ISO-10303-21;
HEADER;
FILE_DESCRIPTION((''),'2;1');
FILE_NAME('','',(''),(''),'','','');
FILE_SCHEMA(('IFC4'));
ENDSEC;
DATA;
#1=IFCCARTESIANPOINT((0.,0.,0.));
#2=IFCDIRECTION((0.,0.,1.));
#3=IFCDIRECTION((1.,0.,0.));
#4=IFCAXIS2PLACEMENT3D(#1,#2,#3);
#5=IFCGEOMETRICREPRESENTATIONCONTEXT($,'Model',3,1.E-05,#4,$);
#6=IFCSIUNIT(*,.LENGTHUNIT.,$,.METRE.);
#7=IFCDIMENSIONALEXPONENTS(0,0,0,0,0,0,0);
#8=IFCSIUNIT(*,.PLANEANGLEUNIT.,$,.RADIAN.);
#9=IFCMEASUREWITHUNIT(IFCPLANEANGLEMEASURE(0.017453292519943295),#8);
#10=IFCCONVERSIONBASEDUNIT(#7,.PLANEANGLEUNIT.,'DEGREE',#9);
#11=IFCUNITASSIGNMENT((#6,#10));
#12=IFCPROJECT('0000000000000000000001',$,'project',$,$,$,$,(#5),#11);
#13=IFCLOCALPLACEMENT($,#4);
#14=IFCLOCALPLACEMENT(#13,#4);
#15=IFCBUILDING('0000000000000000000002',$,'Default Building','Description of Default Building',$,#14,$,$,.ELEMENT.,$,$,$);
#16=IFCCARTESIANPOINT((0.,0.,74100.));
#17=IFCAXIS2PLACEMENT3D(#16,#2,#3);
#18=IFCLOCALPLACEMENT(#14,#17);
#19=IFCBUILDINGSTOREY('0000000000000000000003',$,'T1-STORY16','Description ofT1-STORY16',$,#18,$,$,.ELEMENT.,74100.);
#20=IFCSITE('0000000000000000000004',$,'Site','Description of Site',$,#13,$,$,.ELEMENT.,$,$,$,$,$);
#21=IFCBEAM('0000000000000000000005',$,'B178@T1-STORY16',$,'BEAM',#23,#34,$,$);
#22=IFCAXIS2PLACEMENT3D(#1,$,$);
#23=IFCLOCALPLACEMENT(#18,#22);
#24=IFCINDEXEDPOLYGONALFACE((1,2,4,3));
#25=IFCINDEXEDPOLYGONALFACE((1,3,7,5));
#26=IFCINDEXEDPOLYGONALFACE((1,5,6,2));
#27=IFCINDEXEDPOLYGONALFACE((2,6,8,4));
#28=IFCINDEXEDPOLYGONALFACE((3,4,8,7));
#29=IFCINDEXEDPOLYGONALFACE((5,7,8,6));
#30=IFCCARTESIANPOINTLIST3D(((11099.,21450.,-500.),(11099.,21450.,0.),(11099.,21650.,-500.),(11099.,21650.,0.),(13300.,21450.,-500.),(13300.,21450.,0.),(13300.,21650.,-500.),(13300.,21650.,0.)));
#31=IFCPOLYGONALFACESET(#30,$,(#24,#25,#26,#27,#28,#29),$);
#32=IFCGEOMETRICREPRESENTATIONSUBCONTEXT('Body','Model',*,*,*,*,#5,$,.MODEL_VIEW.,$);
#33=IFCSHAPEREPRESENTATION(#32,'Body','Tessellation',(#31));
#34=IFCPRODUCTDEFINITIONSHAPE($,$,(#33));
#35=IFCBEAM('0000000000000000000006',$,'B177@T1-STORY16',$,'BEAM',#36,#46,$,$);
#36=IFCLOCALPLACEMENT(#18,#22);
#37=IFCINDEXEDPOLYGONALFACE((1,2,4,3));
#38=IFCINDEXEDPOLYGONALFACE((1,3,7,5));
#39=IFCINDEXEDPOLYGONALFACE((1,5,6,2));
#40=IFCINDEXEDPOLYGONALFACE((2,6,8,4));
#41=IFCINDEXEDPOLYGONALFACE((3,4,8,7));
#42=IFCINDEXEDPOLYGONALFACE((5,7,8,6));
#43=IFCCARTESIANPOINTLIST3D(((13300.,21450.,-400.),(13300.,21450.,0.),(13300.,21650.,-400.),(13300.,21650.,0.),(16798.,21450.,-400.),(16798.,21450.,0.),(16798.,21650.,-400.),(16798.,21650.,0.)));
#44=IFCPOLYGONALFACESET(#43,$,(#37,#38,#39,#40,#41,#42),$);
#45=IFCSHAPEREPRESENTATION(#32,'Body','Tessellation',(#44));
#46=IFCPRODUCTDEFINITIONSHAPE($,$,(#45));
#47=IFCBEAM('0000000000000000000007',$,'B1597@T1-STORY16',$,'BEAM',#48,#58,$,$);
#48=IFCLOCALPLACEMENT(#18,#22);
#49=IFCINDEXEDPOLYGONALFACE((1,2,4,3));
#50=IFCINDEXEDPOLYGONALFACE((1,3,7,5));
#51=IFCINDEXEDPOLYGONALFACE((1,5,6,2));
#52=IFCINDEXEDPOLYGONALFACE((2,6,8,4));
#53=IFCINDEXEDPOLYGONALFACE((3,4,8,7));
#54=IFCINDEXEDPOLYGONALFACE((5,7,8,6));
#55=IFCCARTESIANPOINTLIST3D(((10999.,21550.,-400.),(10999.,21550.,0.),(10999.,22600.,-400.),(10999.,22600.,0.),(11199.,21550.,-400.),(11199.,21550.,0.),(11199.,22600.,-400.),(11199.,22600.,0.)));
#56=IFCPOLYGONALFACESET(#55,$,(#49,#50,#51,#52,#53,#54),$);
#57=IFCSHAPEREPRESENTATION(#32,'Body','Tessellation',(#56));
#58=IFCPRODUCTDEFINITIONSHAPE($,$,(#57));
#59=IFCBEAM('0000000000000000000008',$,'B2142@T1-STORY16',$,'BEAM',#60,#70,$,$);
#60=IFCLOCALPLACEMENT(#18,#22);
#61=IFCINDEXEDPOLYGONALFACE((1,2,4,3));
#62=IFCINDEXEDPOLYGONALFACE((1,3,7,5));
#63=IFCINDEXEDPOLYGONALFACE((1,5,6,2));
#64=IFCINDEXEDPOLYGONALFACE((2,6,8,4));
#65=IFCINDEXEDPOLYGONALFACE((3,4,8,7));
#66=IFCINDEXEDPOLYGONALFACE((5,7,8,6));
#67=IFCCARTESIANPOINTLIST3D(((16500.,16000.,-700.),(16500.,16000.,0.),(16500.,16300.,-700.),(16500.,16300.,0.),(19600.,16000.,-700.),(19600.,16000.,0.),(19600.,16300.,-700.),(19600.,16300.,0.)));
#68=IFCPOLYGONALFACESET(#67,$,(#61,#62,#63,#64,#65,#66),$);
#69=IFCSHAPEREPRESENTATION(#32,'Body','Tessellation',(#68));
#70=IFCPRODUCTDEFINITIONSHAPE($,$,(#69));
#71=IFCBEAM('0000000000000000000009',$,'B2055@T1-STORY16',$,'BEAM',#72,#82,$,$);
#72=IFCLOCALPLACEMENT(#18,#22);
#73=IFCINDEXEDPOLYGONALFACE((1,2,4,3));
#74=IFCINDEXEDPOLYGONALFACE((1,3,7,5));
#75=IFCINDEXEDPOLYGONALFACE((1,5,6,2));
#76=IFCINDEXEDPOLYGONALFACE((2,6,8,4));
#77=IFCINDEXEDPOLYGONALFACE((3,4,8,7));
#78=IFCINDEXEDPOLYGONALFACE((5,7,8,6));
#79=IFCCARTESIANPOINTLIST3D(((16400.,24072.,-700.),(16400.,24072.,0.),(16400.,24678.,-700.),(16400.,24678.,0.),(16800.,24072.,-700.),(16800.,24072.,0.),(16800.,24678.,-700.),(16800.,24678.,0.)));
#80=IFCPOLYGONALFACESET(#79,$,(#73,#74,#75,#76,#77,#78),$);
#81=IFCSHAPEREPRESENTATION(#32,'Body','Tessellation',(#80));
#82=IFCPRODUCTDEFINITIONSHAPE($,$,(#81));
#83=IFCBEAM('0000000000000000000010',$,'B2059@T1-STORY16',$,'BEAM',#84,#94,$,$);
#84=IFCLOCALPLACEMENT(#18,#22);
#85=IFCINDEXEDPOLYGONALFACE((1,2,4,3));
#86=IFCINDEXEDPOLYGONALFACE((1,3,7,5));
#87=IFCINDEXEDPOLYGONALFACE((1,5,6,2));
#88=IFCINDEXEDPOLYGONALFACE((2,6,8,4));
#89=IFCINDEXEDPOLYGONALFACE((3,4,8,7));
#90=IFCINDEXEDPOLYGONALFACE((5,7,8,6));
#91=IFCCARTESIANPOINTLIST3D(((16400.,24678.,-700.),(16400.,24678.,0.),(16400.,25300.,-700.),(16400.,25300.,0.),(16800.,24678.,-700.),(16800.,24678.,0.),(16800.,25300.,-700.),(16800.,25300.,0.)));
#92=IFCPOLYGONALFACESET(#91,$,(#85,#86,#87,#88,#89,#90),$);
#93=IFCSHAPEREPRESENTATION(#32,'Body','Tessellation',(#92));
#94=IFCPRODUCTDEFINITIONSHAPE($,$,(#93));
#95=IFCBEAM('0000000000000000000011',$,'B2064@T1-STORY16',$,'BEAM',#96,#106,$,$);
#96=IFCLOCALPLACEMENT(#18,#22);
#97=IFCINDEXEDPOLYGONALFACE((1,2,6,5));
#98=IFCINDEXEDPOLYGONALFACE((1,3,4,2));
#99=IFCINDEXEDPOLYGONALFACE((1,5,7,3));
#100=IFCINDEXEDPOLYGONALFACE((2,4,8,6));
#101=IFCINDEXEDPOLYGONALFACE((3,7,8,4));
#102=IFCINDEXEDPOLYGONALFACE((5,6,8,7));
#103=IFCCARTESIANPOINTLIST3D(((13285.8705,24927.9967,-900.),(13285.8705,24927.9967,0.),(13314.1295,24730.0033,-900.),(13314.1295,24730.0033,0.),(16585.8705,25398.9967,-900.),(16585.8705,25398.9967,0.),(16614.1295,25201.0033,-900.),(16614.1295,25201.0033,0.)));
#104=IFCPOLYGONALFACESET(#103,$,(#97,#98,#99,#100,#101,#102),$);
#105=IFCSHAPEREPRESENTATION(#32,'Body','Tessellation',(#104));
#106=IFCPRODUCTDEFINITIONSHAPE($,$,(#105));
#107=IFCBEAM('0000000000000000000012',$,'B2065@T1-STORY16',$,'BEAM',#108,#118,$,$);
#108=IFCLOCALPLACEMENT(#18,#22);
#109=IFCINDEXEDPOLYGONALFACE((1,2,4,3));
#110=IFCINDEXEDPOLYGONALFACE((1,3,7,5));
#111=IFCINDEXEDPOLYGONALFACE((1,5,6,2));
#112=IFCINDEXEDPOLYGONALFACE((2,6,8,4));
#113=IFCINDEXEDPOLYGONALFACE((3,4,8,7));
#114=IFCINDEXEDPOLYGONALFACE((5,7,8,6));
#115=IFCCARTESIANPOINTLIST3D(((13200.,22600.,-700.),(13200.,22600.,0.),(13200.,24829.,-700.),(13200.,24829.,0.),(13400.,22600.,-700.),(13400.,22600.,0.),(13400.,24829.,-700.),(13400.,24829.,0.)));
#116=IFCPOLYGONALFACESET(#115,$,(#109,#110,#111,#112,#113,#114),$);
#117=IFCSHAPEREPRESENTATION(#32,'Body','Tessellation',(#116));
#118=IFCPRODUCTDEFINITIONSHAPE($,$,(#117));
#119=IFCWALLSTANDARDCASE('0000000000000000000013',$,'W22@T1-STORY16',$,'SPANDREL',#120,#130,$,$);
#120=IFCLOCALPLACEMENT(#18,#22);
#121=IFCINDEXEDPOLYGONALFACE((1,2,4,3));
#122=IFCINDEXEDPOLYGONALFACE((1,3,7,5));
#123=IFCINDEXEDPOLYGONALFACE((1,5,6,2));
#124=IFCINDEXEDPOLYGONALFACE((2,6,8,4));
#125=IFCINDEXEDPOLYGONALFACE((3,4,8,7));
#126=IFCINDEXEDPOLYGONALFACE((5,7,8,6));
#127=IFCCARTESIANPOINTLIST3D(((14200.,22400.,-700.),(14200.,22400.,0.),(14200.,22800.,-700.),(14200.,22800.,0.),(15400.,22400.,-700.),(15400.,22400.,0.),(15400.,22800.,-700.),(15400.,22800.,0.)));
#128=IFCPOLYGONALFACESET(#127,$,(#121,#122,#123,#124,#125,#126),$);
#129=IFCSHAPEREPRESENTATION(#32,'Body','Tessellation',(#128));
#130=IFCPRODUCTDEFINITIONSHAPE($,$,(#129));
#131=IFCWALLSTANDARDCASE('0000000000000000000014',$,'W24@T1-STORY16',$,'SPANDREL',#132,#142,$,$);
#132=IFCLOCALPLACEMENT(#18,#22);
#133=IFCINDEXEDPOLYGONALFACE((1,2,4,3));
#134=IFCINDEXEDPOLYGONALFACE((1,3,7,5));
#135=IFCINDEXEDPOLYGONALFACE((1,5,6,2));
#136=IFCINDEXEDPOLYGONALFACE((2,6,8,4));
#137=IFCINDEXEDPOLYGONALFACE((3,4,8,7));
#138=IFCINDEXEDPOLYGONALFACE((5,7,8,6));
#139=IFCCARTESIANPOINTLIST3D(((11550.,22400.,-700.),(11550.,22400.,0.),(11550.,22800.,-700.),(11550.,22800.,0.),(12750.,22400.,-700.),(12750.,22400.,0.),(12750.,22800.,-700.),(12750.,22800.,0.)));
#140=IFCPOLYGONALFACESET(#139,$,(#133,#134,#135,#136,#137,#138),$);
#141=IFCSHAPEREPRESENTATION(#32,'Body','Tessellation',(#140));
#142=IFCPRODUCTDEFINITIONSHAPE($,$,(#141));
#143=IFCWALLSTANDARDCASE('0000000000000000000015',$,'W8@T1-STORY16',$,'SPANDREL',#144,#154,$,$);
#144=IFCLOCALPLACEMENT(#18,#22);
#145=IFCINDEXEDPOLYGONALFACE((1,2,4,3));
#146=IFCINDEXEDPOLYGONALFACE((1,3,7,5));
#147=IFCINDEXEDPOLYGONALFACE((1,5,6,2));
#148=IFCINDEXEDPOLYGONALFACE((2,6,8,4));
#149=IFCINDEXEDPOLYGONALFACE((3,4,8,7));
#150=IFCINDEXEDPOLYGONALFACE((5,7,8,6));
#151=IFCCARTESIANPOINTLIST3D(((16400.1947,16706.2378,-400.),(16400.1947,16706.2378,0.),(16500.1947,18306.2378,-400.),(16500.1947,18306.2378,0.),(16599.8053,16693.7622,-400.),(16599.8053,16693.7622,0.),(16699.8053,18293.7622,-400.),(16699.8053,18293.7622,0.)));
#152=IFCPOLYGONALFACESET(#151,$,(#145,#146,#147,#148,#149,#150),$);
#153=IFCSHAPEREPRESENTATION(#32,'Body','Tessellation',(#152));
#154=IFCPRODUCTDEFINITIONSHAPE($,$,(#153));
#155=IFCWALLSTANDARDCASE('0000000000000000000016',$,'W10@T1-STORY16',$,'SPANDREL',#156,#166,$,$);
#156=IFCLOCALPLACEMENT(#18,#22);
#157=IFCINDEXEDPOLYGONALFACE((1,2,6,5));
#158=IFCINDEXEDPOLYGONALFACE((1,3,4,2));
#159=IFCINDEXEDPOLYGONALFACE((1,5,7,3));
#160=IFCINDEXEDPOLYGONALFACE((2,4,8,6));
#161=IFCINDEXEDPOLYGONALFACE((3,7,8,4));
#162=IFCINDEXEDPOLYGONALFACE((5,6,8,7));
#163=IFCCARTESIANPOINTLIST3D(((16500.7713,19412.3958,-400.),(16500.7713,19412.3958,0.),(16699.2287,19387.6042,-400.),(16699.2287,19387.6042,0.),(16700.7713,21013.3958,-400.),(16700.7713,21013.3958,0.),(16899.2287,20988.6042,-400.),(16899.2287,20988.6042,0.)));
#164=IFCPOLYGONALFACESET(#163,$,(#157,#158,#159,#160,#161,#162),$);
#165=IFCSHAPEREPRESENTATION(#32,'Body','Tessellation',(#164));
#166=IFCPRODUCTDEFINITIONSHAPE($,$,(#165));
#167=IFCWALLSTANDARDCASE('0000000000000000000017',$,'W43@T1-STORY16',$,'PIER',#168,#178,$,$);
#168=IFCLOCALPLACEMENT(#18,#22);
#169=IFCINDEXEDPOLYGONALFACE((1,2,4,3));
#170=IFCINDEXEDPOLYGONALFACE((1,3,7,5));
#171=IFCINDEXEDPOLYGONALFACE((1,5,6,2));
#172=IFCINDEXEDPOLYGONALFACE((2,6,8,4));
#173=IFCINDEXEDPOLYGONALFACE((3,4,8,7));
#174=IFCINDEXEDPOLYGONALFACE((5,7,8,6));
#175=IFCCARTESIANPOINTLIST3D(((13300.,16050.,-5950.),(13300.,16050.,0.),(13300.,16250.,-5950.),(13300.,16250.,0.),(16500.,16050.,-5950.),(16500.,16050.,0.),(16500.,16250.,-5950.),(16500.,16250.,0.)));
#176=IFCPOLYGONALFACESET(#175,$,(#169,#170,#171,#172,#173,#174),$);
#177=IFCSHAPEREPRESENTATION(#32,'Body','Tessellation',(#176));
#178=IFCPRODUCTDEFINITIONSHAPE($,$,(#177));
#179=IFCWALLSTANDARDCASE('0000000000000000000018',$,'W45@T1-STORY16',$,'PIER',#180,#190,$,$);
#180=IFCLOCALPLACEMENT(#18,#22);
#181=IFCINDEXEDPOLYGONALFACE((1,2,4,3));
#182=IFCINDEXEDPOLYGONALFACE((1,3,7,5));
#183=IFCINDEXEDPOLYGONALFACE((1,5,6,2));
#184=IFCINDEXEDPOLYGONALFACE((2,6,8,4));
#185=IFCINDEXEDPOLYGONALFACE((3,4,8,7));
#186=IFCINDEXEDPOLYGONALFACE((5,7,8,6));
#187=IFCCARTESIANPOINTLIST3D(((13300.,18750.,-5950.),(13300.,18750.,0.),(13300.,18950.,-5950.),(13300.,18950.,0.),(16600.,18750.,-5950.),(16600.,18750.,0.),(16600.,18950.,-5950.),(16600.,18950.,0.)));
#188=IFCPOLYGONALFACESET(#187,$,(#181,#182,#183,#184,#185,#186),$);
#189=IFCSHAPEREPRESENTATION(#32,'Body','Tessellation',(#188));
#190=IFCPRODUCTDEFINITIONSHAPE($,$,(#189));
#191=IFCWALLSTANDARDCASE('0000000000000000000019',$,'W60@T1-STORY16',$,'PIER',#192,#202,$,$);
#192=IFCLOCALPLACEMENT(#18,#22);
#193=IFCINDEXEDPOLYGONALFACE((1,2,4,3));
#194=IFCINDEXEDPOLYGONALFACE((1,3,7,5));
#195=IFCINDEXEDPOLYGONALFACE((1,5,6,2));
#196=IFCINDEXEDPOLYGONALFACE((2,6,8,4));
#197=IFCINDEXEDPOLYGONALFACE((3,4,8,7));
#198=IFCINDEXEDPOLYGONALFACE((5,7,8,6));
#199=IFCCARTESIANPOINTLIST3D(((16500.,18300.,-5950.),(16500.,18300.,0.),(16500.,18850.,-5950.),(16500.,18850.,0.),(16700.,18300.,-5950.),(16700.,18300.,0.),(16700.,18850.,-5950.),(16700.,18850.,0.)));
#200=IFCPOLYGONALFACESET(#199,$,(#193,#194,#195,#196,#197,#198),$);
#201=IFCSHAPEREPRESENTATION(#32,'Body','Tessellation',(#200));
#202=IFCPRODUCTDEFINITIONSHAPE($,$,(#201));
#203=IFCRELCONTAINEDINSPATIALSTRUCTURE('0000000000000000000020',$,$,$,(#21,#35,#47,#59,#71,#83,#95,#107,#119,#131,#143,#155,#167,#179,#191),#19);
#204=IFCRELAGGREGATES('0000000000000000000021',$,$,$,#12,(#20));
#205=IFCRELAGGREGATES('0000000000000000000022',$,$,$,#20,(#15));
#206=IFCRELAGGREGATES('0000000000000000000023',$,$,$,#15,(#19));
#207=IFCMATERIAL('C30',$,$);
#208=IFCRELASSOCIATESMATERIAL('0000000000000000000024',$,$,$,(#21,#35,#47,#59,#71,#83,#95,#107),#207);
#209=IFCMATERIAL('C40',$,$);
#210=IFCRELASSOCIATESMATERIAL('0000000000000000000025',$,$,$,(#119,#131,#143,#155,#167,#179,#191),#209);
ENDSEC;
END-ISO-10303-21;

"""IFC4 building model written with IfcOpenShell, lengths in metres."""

from ifc_helpers import new_model, entity, si_unit, converted_unit, frame, origin_with_axes, place, context, subcontext, project, spatial, indexed_curve, rectangle, outline, extrude, material, element, save


model = new_model("IFC4")

# Units and contexts
model_context = context("Model", 3, precision=1e-05, world=origin_with_axes())
body_context = subcontext(model_context, "Body", "Model", "MODEL_VIEW")
ifc_project = project(units=[si_unit("LENGTHUNIT", "METRE"), converted_unit("PLANEANGLEUNIT", "DEGREE", entity("IfcPlaneAngleMeasure", 0.017453292519943295), si_unit("PLANEANGLEUNIT", "RADIAN"), dimensions=[0, 0, 0, 0, 0, 0, 0])], contexts=[model_context])

# Site, building, storey
site_placement = place(None, origin_with_axes())
site = spatial("IfcSite", under=ifc_project, at=site_placement, Name="Site", Description="Description of Site", CompositionType="ELEMENT")
building_placement = place(site_placement, origin_with_axes())
building = spatial("IfcBuilding", under=site, at=building_placement, Name="Default Building", Description="Description of Default Building", CompositionType="ELEMENT")
storey_placement = place(building_placement, frame((0.0, 0.0, 74100.0), z_axis=(0.0, 0.0, 1.0), x_axis=(1.0, 0.0, 0.0)))
storey = spatial("IfcBuildingStorey", under=building, at=storey_placement, Name="T1-STORY16", Description="Description ofT1-STORY16", CompositionType="ELEMENT", Elevation=74100.0)

# Beams
ifc_material_1 = material(Name="C30")
beam_1_placement = place(storey_placement, frame((11099.0, 21550.0, -250.0), z_axis=(1.0, 0.0, 0.0), x_axis=(0.0, 1.0, 0.0)))
element("IfcBeam", 1, at=beam_1_placement, inside=storey, material=ifc_material_1, Name="B178@T1-STORY16", ObjectType="BEAM", context=body_context, shape_type="SweptSolid", body=[
    extrude(rectangle(XDim=200.0, YDim=500.0), origin_with_axes(), (0.0, 0.0, 1.0), 2201.0),
])
beam_2_placement = place(storey_placement, frame((13300.0, 21550.0, -200.0), z_axis=(1.0, 0.0, 0.0), x_axis=(0.0, 1.0, 0.0)))
element("IfcBeam", 2, at=beam_2_placement, inside=storey, material=ifc_material_1, Name="B177@T1-STORY16", ObjectType="BEAM", context=body_context, shape_type="SweptSolid", body=[
    extrude(rectangle(XDim=200.0, YDim=400.0), origin_with_axes(), (0.0, 0.0, 1.0), 3498.0),
])
beam_3_placement = place(storey_placement, frame((11099.0, 21550.0, -200.0), z_axis=(0.0, 1.0, 0.0), x_axis=(-1.0, 0.0, 0.0)))
element("IfcBeam", 3, at=beam_3_placement, inside=storey, material=ifc_material_1, Name="B1597@T1-STORY16", ObjectType="BEAM", context=body_context, shape_type="SweptSolid", body=[
    extrude(rectangle(XDim=200.0, YDim=400.0), origin_with_axes(), (0.0, 0.0, 1.0), 1050.0),
])
beam_4_placement = place(storey_placement, frame((16500.0, 16150.0, -350.0), z_axis=(1.0, 0.0, 0.0), x_axis=(0.0, 1.0, 0.0)))
element("IfcBeam", 4, at=beam_4_placement, inside=storey, material=ifc_material_1, Name="B2142@T1-STORY16", ObjectType="BEAM", context=body_context, shape_type="SweptSolid", body=[
    extrude(rectangle(XDim=300.0, YDim=700.0), origin_with_axes(), (0.0, 0.0, 1.0), 3100.0),
])
beam_5_placement = place(storey_placement, frame((16600.0, 24072.0, -350.0), z_axis=(0.0, 1.0, 0.0), x_axis=(-1.0, 0.0, 0.0)))
element("IfcBeam", 5, at=beam_5_placement, inside=storey, material=ifc_material_1, Name="B2055@T1-STORY16", ObjectType="BEAM", context=body_context, shape_type="SweptSolid", body=[
    extrude(rectangle(XDim=400.0, YDim=700.0), origin_with_axes(), (0.0, 0.0, 1.0), 606.0),
])
beam_6_placement = place(storey_placement, frame((16600.0, 24678.0, -350.0), z_axis=(0.0, 1.0, 0.0), x_axis=(-1.0, 0.0, 0.0)))
element("IfcBeam", 6, at=beam_6_placement, inside=storey, material=ifc_material_1, Name="B2059@T1-STORY16", ObjectType="BEAM", context=body_context, shape_type="SweptSolid", body=[
    extrude(rectangle(XDim=400.0, YDim=700.0), origin_with_axes(), (0.0, 0.0, 1.0), 622.0),
])
beam_7_placement = place(storey_placement, frame((13300.0, 24829.0, -450.0), z_axis=(0.989967, 0.141295, 0.0), x_axis=(-0.141295, 0.989967, 0.0)))
element("IfcBeam", 7, at=beam_7_placement, inside=storey, material=ifc_material_1, Name="B2064@T1-STORY16", ObjectType="BEAM", context=body_context, shape_type="SweptSolid", body=[
    extrude(rectangle(XDim=200.0, YDim=900.0), origin_with_axes(), (0.0, 0.0, 1.0), 3333.4428),
])
beam_8_placement = place(storey_placement, frame((13300.0, 22600.0, -350.0), z_axis=(0.0, 1.0, 0.0), x_axis=(-1.0, 0.0, 0.0)))
element("IfcBeam", 8, at=beam_8_placement, inside=storey, material=ifc_material_1, Name="B2065@T1-STORY16", ObjectType="BEAM", context=body_context, shape_type="SweptSolid", body=[
    extrude(rectangle(XDim=200.0, YDim=700.0), origin_with_axes(), (0.0, 0.0, 1.0), 2229.0),
])

# Walls
ifc_material_2 = material(Name="C40")
for number, where, z_axis, x_axis, name in (
    (9, (14200.0, 22600.0, -700.0), (0.0, 0.0, 1.0), (1.0, 0.0, 0.0), "W22@T1-STORY16"),
    (10, (11550.0, 22600.0, -700.0), (0.0, 0.0, 1.0), (1.0, 0.0, 0.0), "W24@T1-STORY16"),
):
    element("IfcWallStandardCase", number, at=place(storey_placement, frame(where, z_axis=z_axis, x_axis=x_axis)), inside=storey, material=ifc_material_2, Name=name, ObjectType="SPANDREL", context=body_context, shape_type="SweptSolid", body=[
        extrude(outline(indexed_curve([(0.0, -200.0), (0.0, 200.0), (1200.0, 200.0), (1200.0, -200.0), (0.0, -200.0)], self_intersect=False)), origin_with_axes(), (0.0, 0.0, 1.0), 700.0),
    ])
wall_1_placement = place(storey_placement, frame((16500.0, 16700.0, -400.0), z_axis=(0.0, 0.0, 1.0), x_axis=(0.062378, 0.998053, 0.0)))
element("IfcWallStandardCase", 11, at=wall_1_placement, inside=storey, material=ifc_material_2, Name="W8@T1-STORY16", ObjectType="SPANDREL", context=body_context, shape_type="SweptSolid", body=[
    extrude(outline(indexed_curve([(0.0, -100.0), (0.0, 100.0), (1603.122, 100.0), (1603.122, -100.0), (0.0, -100.0)], self_intersect=False)), origin_with_axes(), (0.0, 0.0, 1.0), 400.0),
])
wall_2_placement = place(storey_placement, frame((16600.0, 19400.0, -400.0), z_axis=(0.0, 0.0, 1.0), x_axis=(0.123958, 0.992287, 0.0)))
element("IfcWallStandardCase", 12, at=wall_2_placement, inside=storey, material=ifc_material_2, Name="W10@T1-STORY16", ObjectType="SPANDREL", context=body_context, shape_type="SweptSolid", body=[
    extrude(outline(indexed_curve([(0.0, -100.0), (0.0, 100.0), (1613.4438, 100.0), (1613.4438, -100.0), (0.0, -100.0)], self_intersect=False)), origin_with_axes(), (0.0, 0.0, 1.0), 400.0),
])
wall_3_placement = place(storey_placement, frame((13300.0, 16150.0, -5950.0), z_axis=(0.0, 0.0, 1.0), x_axis=(1.0, 0.0, 0.0)))
element("IfcWallStandardCase", 13, at=wall_3_placement, inside=storey, material=ifc_material_2, Name="W43@T1-STORY16", ObjectType="PIER", context=body_context, shape_type="SweptSolid", body=[
    extrude(outline(indexed_curve([(0.0, -100.0), (0.0, 100.0), (3200.0, 100.0), (3200.0, -100.0), (0.0, -100.0)], self_intersect=False)), origin_with_axes(), (0.0, 0.0, 1.0), 5950.0),
])
wall_4_placement = place(storey_placement, frame((13300.0, 18850.0, -5950.0), z_axis=(0.0, 0.0, 1.0), x_axis=(1.0, 0.0, 0.0)))
element("IfcWallStandardCase", 14, at=wall_4_placement, inside=storey, material=ifc_material_2, Name="W45@T1-STORY16", ObjectType="PIER", context=body_context, shape_type="SweptSolid", body=[
    extrude(outline(indexed_curve([(0.0, -100.0), (0.0, 100.0), (3300.0, 100.0), (3300.0, -100.0), (0.0, -100.0)], self_intersect=False)), origin_with_axes(), (0.0, 0.0, 1.0), 5950.0),
])
for number, where, z_axis, x_axis, name in (
    (15, (16600.0, 18300.0, -5950.0), (0.0, 0.0, 1.0), (0.0, 1.0, 0.0), "W60@T1-STORY16"),
):
    element("IfcWallStandardCase", number, at=place(storey_placement, frame(where, z_axis=z_axis, x_axis=x_axis)), inside=storey, material=ifc_material_2, Name=name, ObjectType="PIER", context=body_context, shape_type="SweptSolid", body=[
        extrude(outline(indexed_curve([(0.0, -100.0), (0.0, 100.0), (550.0, 100.0), (550.0, -100.0), (0.0, -100.0)], self_intersect=False)), origin_with_axes(), (0.0, 0.0, 1.0), 5950.0),
    ])

save(model, "model.ifc")
